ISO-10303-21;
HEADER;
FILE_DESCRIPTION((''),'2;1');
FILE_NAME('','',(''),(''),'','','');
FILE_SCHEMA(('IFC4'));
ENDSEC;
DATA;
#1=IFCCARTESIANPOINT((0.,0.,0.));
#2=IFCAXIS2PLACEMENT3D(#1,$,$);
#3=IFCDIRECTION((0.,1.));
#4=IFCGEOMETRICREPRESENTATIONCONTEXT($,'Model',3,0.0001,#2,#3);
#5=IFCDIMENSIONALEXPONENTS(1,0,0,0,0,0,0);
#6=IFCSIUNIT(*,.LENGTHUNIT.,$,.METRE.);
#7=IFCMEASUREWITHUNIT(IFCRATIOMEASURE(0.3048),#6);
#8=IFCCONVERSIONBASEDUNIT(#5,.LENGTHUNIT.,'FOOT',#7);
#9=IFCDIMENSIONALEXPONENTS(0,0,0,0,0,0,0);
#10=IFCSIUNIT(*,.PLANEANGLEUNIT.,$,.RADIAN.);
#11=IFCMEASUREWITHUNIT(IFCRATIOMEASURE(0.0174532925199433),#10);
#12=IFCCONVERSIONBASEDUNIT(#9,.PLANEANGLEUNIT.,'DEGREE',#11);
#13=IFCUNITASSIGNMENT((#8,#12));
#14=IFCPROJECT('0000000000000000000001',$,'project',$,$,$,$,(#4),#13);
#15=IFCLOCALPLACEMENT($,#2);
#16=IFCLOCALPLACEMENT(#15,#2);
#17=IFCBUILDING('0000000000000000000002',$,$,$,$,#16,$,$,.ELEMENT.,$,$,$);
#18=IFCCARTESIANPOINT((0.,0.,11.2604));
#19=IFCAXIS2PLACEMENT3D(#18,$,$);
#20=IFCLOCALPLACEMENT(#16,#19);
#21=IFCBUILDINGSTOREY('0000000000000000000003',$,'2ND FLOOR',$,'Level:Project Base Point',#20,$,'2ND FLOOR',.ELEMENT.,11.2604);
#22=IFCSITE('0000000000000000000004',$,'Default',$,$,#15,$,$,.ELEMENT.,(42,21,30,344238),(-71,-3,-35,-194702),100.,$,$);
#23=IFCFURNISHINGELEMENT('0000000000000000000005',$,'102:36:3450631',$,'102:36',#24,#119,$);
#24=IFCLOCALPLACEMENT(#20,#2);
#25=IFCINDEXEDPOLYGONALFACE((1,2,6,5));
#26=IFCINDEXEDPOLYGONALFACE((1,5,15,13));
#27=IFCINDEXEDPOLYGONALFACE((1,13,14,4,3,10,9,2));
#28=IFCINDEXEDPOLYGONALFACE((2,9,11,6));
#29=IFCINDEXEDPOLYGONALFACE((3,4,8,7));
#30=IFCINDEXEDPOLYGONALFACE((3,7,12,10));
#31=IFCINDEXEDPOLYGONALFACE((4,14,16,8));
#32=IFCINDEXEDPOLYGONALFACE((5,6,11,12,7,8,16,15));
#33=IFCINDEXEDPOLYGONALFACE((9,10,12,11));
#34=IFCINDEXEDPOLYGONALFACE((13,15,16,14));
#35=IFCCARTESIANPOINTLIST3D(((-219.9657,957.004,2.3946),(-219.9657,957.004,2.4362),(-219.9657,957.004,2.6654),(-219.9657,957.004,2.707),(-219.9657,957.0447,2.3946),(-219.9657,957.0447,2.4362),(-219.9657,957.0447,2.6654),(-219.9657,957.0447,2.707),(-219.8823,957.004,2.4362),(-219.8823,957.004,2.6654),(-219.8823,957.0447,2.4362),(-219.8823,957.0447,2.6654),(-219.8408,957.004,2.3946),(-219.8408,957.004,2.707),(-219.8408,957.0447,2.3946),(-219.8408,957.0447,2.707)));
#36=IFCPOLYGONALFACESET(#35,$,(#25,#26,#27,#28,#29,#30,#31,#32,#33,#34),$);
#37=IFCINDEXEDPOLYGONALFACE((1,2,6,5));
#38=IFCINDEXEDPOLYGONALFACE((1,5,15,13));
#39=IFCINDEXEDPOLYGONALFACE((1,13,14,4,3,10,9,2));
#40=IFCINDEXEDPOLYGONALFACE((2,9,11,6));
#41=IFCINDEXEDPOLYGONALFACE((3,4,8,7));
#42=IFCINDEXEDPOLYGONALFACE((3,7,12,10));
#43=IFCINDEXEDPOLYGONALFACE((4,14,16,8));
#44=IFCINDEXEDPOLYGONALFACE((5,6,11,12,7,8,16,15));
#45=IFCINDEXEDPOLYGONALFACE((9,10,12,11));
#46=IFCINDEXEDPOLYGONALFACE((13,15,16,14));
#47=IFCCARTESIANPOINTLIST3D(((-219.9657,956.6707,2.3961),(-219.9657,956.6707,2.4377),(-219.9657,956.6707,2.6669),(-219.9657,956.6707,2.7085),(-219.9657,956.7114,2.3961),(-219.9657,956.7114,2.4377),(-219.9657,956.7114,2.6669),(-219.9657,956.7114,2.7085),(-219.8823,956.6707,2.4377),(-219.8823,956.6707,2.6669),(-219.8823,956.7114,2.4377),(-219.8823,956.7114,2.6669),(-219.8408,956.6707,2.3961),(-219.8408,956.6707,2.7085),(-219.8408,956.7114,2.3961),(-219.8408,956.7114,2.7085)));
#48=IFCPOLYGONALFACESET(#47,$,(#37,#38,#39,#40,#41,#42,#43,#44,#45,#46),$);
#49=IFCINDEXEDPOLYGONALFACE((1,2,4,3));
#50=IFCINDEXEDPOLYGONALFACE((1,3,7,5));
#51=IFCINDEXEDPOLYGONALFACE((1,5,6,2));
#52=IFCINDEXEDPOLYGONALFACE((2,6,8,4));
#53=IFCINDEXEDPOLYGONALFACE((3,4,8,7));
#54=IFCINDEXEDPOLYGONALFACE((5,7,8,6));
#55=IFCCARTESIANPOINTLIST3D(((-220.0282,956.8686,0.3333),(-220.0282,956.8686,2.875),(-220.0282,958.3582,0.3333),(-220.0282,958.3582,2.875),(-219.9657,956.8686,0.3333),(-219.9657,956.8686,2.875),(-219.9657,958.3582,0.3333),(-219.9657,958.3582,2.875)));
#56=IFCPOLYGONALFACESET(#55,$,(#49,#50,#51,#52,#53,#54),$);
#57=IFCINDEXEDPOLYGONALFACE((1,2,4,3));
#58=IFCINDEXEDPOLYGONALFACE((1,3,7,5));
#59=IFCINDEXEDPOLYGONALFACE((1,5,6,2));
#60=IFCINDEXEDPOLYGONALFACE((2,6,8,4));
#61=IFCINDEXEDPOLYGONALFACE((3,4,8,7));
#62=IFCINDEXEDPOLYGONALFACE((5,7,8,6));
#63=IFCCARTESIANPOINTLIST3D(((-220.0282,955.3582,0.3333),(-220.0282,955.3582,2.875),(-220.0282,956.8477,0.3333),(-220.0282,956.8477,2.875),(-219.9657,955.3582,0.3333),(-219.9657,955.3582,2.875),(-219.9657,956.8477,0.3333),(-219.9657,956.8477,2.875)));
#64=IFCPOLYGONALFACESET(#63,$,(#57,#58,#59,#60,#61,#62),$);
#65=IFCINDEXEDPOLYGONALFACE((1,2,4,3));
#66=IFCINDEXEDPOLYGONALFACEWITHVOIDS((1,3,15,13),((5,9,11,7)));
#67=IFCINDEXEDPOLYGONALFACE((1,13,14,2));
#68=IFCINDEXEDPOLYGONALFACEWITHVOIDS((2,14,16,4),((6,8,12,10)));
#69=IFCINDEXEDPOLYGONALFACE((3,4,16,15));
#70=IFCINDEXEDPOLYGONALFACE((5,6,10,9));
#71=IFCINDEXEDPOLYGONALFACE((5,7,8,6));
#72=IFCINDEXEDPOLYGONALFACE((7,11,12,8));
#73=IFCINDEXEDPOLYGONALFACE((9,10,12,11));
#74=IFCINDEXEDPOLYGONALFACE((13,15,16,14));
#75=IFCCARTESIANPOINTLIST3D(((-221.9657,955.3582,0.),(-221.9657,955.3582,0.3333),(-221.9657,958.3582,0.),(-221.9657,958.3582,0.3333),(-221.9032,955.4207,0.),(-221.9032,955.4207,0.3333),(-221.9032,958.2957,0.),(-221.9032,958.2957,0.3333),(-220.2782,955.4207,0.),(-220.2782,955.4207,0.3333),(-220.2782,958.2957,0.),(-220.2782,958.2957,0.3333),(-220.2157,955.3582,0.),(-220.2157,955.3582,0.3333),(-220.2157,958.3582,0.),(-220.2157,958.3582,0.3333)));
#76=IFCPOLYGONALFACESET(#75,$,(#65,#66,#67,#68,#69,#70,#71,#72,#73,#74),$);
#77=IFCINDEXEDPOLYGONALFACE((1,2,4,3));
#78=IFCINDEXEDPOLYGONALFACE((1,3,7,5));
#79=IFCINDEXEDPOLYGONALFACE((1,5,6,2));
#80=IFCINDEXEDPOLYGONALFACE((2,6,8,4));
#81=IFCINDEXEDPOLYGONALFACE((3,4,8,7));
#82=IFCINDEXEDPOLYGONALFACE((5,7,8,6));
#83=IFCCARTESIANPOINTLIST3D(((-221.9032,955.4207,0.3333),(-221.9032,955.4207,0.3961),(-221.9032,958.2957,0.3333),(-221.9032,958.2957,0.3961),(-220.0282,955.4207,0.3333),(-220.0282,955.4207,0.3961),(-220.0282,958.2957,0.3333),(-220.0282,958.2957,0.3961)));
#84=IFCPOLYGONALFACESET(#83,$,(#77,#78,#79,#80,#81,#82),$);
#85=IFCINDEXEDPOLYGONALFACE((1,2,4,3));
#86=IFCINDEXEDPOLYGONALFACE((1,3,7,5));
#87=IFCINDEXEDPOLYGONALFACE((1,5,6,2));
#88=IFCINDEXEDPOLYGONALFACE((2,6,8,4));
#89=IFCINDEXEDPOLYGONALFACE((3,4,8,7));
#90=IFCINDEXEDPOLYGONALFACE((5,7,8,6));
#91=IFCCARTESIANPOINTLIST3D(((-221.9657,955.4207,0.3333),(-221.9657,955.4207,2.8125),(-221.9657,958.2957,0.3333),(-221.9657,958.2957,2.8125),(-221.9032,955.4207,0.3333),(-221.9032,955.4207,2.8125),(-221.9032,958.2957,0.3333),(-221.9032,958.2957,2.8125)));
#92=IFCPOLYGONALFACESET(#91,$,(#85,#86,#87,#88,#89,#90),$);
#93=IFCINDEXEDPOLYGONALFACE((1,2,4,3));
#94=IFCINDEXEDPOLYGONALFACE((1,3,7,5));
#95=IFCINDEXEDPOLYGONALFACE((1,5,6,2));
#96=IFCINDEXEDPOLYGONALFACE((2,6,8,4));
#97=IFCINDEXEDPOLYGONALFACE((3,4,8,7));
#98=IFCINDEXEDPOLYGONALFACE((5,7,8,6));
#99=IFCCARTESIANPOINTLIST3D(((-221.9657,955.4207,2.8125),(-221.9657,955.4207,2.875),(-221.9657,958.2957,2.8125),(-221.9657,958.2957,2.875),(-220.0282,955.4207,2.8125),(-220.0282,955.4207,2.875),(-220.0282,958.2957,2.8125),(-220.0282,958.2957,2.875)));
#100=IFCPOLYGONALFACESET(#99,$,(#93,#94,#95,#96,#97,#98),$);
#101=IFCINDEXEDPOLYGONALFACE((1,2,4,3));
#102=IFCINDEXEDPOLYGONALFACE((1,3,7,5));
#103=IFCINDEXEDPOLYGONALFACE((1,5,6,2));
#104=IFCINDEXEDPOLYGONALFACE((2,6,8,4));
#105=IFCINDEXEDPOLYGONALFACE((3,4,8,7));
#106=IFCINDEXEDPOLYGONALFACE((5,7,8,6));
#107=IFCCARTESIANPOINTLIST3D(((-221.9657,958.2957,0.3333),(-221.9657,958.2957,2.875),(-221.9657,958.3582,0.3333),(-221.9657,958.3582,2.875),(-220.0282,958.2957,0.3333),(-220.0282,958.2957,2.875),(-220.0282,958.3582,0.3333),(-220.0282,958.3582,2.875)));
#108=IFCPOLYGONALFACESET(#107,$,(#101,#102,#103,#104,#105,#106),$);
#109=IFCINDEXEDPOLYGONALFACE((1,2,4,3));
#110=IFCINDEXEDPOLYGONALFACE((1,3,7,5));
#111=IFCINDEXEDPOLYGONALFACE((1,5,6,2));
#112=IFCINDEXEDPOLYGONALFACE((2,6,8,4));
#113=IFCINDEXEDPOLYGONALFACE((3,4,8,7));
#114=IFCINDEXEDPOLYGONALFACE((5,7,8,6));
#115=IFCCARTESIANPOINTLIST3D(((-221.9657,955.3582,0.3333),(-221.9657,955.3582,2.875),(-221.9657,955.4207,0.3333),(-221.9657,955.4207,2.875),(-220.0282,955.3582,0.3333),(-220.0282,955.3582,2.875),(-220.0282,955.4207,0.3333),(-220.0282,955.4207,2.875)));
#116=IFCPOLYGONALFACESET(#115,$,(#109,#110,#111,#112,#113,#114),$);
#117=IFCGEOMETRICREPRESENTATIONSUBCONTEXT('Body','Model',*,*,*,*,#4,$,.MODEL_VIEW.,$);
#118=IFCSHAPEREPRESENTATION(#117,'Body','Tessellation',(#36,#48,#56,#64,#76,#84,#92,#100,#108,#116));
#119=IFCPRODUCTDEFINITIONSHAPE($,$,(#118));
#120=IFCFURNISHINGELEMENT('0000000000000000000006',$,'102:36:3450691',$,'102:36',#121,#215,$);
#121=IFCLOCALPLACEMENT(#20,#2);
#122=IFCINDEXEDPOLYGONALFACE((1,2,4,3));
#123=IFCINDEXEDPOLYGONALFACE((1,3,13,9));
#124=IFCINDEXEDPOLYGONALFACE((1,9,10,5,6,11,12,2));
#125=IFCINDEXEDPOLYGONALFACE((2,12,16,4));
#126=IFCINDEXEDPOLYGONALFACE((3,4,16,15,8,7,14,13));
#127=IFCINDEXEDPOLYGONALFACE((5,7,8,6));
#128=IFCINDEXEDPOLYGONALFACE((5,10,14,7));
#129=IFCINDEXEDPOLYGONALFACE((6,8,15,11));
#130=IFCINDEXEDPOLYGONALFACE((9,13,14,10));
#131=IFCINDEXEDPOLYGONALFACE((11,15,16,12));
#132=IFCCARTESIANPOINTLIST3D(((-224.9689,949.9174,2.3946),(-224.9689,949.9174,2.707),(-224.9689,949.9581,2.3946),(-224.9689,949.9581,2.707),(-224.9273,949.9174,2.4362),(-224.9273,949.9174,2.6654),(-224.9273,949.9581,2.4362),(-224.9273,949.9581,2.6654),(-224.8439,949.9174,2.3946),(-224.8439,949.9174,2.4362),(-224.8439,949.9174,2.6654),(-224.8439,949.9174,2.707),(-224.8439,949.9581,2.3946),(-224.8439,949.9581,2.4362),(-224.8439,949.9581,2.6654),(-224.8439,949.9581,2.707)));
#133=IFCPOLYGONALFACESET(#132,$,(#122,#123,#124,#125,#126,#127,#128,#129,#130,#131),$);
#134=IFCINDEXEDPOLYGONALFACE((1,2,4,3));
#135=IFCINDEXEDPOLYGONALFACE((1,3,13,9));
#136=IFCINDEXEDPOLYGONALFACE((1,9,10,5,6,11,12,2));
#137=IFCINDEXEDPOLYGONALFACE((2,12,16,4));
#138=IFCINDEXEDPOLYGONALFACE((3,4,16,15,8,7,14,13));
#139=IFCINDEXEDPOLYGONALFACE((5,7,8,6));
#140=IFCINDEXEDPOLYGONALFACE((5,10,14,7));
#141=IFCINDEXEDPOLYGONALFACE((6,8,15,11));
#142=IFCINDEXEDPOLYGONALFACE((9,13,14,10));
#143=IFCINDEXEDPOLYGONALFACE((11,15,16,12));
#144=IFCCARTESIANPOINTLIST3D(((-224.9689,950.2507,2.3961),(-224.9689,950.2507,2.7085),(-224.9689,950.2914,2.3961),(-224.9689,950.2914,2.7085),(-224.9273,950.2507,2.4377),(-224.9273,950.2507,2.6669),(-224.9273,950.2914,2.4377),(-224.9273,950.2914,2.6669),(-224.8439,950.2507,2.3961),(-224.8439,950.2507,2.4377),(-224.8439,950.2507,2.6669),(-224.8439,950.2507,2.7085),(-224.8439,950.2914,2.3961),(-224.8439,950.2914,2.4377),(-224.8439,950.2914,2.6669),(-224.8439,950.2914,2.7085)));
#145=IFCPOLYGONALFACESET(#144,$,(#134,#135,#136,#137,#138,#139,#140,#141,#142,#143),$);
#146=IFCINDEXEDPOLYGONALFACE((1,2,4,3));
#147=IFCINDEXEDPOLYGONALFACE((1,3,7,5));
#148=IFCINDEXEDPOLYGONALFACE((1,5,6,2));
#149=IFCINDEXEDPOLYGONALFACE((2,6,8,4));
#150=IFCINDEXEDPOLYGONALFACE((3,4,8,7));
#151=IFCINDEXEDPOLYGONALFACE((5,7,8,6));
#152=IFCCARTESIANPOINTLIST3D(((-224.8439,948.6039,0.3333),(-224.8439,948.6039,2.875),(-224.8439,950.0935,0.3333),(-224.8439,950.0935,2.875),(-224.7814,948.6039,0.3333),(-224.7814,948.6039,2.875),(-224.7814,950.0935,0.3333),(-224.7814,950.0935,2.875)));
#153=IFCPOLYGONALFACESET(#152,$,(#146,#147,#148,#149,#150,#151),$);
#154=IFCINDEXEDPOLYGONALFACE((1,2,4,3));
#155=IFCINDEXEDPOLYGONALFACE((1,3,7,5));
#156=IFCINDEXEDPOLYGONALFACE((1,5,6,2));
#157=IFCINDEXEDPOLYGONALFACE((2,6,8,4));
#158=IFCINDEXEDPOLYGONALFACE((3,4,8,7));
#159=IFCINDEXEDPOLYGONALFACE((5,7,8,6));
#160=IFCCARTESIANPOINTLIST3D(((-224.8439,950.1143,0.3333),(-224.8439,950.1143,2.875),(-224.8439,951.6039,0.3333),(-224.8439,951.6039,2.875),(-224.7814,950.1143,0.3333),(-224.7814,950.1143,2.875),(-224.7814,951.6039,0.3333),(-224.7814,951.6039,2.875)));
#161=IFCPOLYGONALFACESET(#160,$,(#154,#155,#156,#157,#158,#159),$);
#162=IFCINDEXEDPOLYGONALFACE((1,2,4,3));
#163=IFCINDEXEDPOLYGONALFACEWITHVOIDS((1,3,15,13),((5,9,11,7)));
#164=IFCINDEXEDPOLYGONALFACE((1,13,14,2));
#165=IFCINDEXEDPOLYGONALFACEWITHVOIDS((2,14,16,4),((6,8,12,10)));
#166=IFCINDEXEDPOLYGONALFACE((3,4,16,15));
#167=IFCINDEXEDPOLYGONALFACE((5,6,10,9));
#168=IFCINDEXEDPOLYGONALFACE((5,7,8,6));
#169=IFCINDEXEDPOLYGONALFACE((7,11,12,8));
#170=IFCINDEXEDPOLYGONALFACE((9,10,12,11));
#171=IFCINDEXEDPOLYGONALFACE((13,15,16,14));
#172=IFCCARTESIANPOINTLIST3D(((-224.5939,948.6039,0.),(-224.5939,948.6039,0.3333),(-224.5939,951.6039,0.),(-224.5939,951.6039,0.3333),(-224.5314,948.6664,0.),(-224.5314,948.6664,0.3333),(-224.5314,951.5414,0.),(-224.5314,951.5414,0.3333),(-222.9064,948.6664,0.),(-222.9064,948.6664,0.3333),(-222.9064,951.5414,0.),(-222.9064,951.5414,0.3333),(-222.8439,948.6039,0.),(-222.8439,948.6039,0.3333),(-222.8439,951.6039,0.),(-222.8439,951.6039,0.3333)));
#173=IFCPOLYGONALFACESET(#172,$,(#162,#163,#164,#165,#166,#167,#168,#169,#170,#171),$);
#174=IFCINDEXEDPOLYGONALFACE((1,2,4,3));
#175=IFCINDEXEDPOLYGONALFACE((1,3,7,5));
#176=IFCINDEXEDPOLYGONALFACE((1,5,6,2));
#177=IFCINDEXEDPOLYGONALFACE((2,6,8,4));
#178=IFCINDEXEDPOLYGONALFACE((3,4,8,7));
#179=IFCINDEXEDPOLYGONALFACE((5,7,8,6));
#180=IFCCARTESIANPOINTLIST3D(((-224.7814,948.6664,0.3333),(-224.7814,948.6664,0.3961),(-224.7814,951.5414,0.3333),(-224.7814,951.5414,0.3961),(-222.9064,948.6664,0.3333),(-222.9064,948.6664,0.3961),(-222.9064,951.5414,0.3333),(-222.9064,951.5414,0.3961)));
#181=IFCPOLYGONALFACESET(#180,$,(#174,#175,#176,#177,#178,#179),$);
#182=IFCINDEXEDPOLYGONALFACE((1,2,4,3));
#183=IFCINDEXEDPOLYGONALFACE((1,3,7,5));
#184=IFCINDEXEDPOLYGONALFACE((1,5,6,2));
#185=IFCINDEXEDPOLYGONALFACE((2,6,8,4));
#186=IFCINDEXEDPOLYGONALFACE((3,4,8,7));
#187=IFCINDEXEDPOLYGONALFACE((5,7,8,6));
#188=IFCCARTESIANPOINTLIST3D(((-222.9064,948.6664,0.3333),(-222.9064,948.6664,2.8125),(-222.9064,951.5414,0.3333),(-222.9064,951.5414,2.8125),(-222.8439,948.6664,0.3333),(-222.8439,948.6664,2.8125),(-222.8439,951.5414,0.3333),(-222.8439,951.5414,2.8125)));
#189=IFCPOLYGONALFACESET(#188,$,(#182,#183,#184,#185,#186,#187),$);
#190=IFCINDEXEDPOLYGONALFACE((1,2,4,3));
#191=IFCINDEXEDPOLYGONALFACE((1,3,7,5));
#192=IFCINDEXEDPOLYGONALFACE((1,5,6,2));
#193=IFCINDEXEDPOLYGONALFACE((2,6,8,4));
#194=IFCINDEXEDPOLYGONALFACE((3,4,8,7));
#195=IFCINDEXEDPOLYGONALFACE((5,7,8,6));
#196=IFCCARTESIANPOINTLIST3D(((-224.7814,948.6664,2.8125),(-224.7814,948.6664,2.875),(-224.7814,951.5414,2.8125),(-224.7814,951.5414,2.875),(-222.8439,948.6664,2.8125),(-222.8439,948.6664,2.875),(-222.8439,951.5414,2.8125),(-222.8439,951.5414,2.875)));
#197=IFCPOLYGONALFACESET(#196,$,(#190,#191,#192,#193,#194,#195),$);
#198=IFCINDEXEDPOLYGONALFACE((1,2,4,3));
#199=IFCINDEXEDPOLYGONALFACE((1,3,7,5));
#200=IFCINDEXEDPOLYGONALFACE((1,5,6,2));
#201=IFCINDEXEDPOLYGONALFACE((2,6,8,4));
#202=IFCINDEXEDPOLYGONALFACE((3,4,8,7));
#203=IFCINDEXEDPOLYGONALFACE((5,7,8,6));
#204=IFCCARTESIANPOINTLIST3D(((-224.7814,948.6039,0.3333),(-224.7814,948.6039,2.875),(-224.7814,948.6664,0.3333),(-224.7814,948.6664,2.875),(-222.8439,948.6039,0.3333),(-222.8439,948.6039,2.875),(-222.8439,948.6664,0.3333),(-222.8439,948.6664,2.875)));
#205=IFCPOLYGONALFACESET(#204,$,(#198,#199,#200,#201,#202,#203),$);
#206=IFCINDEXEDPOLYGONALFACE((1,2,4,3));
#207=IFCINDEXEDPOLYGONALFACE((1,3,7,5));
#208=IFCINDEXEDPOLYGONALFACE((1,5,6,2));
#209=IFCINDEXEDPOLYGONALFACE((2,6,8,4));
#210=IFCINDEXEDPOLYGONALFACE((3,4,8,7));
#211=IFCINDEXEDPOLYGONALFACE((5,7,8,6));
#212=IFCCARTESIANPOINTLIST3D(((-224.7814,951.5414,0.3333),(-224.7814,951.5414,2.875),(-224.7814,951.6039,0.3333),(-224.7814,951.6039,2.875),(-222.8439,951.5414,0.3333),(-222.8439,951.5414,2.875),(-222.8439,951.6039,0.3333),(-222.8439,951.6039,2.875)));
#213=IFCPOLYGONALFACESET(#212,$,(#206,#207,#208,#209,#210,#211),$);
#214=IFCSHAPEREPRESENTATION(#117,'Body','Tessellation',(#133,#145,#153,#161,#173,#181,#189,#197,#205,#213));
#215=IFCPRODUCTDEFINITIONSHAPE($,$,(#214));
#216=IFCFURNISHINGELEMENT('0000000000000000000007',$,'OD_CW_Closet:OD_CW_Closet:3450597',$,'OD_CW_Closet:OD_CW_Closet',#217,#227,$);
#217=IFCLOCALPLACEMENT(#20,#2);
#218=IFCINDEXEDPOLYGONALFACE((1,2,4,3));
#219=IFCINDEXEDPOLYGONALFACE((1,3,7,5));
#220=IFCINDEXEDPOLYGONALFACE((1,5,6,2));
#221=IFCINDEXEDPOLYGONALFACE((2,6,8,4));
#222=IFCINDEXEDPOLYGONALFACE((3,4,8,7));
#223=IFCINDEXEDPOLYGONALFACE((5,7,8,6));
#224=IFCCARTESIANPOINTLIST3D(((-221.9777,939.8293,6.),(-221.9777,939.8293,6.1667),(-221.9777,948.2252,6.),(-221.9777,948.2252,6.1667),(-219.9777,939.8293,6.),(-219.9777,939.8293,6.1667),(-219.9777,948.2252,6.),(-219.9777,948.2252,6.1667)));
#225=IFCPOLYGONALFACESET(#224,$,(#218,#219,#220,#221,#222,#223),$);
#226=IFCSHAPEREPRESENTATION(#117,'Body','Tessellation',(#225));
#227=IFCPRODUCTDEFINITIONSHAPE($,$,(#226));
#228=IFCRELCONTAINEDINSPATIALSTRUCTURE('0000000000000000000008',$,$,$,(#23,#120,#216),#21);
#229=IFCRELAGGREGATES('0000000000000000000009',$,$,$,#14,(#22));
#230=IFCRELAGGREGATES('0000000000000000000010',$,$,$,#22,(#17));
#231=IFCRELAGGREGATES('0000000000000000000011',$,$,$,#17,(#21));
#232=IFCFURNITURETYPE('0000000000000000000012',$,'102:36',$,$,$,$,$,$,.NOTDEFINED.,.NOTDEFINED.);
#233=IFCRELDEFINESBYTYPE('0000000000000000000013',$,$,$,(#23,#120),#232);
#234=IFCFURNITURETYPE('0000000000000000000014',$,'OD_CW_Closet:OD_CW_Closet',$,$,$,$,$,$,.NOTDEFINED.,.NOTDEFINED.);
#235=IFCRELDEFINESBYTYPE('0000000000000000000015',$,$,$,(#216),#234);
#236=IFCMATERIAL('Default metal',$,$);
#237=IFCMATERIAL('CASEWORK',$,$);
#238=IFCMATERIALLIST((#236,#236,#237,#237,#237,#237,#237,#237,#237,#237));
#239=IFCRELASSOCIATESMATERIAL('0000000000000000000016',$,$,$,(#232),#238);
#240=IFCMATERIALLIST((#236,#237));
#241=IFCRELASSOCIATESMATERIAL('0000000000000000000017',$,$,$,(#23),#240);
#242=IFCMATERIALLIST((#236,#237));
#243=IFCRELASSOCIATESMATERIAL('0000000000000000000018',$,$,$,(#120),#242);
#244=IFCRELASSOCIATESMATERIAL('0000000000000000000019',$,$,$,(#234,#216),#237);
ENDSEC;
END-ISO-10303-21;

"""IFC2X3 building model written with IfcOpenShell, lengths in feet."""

from ifc_helpers import new_model, entity, si_unit, converted_unit, direction, frame, frame_2d, origin, origin_2d_with_axis, place, context, subcontext, project, spatial, polyline, rectangle, outline, extrude, source, transform, mapped, material, material_list, type_object, type_shapes, element, save


model = new_model("IFC2X3")

# Units and contexts
model_context = context("Model", 3, precision=0.0001, world=origin(), true_north=direction((0.0, 1.0)))
body_context = subcontext(model_context, "Body", "Model", "MODEL_VIEW")
ifc_project = project(units=[converted_unit("LENGTHUNIT", "FOOT", entity("IfcRatioMeasure", 0.3048), si_unit("LENGTHUNIT", "METRE"), dimensions=[1, 0, 0, 0, 0, 0, 0]), converted_unit("PLANEANGLEUNIT", "DEGREE", entity("IfcRatioMeasure", 0.0174532925199433), si_unit("PLANEANGLEUNIT", "RADIAN"), dimensions=[0, 0, 0, 0, 0, 0, 0])], contexts=[model_context])

# Site, building, storey
site_placement = place(None, origin())
site = spatial("IfcSite", under=ifc_project, at=site_placement, Name="Default", CompositionType="ELEMENT", RefLatitude=(42, 21, 30, 344238), RefLongitude=(-71, -3, -35, -194702), RefElevation=100.0)
building_placement = place(site_placement, origin())
building = spatial("IfcBuilding", under=site, at=building_placement, CompositionType="ELEMENT")
storey_placement = place(building_placement, frame((0.0, 0.0, 11.2604)))
storey = spatial("IfcBuildingStorey", under=building, at=storey_placement, Name="2ND FLOOR", ObjectType="Level:Project Base Point", LongName="2ND FLOOR", CompositionType="ELEMENT", Elevation=11.2604)

# Furnishing elements
ifc_material_1 = material(Name="Default metal")
ifc_material_2 = material(Name="CASEWORK")
ifc_material_list_1 = material_list([ifc_material_1, ifc_material_2])
ifc_material_list_2 = material_list([ifc_material_1, ifc_material_1, ifc_material_2, ifc_material_2, ifc_material_2, ifc_material_2, ifc_material_2, ifc_material_2, ifc_material_2, ifc_material_2])
furniture_type_1 = type_object("IfcFurnitureType", Name="102:36", material=ifc_material_list_2)
shared_shape_1 = source(origin(), body_context, "Body", "SweptSolid", [
    extrude(outline(polyline([(0.1146, -0.0521), (0.1562, -0.0521), (0.1562, 0.0729), (-0.1562, 0.0729), (-0.1562, -0.0521), (-0.1146, -0.0521), (-0.1146, 0.0313), (0.1146, 0.0313), (0.1146, -0.0521)])), frame((0.2073, -2.0521, 2.5508), z_axis=(1.0, 0.0, 0.0), x_axis=(0.0, 0.0, 1.0)), (0.0, 0.0, 1.0), 0.0407),
    extrude(outline(polyline([(0.1146, -0.0521), (0.1562, -0.0521), (0.1562, 0.0729), (-0.1562, 0.0729), (-0.1562, -0.0521), (-0.1146, -0.0521), (-0.1146, 0.0313), (0.1146, 0.0313), (0.1146, -0.0521)])), frame((-0.126, -2.0521, 2.5523), z_axis=(1.0, 0.0, 0.0), x_axis=(0.0, 0.0, 1.0)), (0.0, 0.0, 1.0), 0.0407),
    extrude(rectangle(XDim=0.0625, YDim=1.4896, at=frame_2d((0.0, 0.0), x_axis=(1.0, 0.0))), frame((0.8167, -1.9688, 0.3333), z_axis=(0.0, 0.0, 1.0), x_axis=(0.0, 1.0, 0.0)), (0.0, 0.0, 1.0), 2.5417),
    extrude(rectangle(XDim=0.0625, YDim=1.4896, at=origin_2d_with_axis()), frame((-0.6937, -1.9688, 0.3333), z_axis=(0.0, 0.0, 1.0), x_axis=(0.0, 1.0, 0.0)), (0.0, 0.0, 1.0), 2.5417),
    extrude(outline(polyline([(-1.5, -0.875), (1.5, -0.875), (1.5, 0.875), (-1.5, 0.875), (-1.5, -0.875)]), holes=[polyline([(-1.4375, -0.8125), (-1.4375, 0.8125), (1.4375, 0.8125), (1.4375, -0.8125), (-1.4375, -0.8125)])]), frame((0.0615, -0.875, 0.0)), (0.0, 0.0, 1.0), 0.3333),
    extrude(rectangle(XDim=2.875, YDim=1.875, at=origin_2d_with_axis()), frame((0.0615, -1.0, 0.3333), z_axis=(0.0, 0.0, 1.0), x_axis=(-1.0, 0.0, 0.0)), (0.0, 0.0, 1.0), 0.0627),
    extrude(rectangle(XDim=0.0625, YDim=2.875, at=origin_2d_with_axis()), frame((0.0615, -0.0312, 0.3333), z_axis=(0.0, 0.0, 1.0), x_axis=(0.0, 1.0, 0.0)), (0.0, 0.0, 1.0), 2.4792),
    extrude(rectangle(XDim=2.875, YDim=1.9375, at=origin_2d_with_axis()), frame((0.0615, -0.9688, 2.8125), z_axis=(0.0, 0.0, 1.0), x_axis=(-1.0, 0.0, 0.0)), (0.0, 0.0, 1.0), 0.0625),
    extrude(rectangle(XDim=0.0625, YDim=1.9375, at=frame_2d((0.0, 0.0), x_axis=(1.0, 0.0))), frame((1.5302, -0.9687, 0.3333)), (0.0, 0.0, 1.0), 2.5417),
    extrude(rectangle(XDim=0.0625, YDim=1.9375, at=frame_2d((0.0, 0.0), x_axis=(1.0, 0.0))), frame((-1.4073, -0.9687, 0.3333)), (0.0, 0.0, 1.0), 2.5417),
])
type_shapes(furniture_type_1, [shared_shape_1])
furnishing_1_placement = place(storey_placement, frame((-221.9657, 956.7967, 0.0), z_axis=(0.0, 0.0, 1.0), x_axis=(0.0, 1.0, 0.0)))
element("IfcFurnishingElement", 1, at=furnishing_1_placement, inside=storey, type_object=furniture_type_1, material=ifc_material_list_1, Name="102:36:3450631", ObjectType="102:36", context=body_context, shape_type="MappedRepresentation", body=[
    mapped(shared_shape_1, transform((0.0, 0.0, 0.0), scale=1.0)),
])
ifc_material_list_3 = material_list([ifc_material_1, ifc_material_2])
furnishing_2_placement = place(storey_placement, frame((-222.8439, 950.1654, 0.0), z_axis=(0.0, 0.0, 1.0), x_axis=(0.0, -1.0, 0.0)))
element("IfcFurnishingElement", 2, at=furnishing_2_placement, inside=storey, type_object=furniture_type_1, material=ifc_material_list_3, Name="102:36:3450691", ObjectType="102:36", context=body_context, shape_type="MappedRepresentation", body=[
    mapped(shared_shape_1, transform((0.0, 0.0, 0.0), scale=1.0)),
])
furniture_type_2 = type_object("IfcFurnitureType", Name="OD_CW_Closet:OD_CW_Closet", material=ifc_material_2)
shared_shape_2 = source(origin(), body_context, "Body", "SweptSolid", [
    extrude(rectangle(XDim=8.3958, YDim=2.0, at=frame_2d((0.0, 0.0), x_axis=(1.0, 0.0))), frame((4.1979, 1.0, 0.0)), (0.0, 0.0, 1.0), 0.1667),
])
type_shapes(furniture_type_2, [shared_shape_2])
furnishing_3_placement = place(storey_placement, frame((-221.9777, 948.2252, 6.0), z_axis=(0.0, 0.0, 1.0), x_axis=(0.0, -1.0, 0.0)))
element("IfcFurnishingElement", 3, at=furnishing_3_placement, inside=storey, type_object=furniture_type_2, material=ifc_material_2, Name="OD_CW_Closet:OD_CW_Closet:3450597", ObjectType="OD_CW_Closet:OD_CW_Closet", context=body_context, shape_type="MappedRepresentation", body=[
    mapped(shared_shape_2, transform((0.0, 0.0, 0.0), scale=1.0)),
])

save(model, "model.ifc")
